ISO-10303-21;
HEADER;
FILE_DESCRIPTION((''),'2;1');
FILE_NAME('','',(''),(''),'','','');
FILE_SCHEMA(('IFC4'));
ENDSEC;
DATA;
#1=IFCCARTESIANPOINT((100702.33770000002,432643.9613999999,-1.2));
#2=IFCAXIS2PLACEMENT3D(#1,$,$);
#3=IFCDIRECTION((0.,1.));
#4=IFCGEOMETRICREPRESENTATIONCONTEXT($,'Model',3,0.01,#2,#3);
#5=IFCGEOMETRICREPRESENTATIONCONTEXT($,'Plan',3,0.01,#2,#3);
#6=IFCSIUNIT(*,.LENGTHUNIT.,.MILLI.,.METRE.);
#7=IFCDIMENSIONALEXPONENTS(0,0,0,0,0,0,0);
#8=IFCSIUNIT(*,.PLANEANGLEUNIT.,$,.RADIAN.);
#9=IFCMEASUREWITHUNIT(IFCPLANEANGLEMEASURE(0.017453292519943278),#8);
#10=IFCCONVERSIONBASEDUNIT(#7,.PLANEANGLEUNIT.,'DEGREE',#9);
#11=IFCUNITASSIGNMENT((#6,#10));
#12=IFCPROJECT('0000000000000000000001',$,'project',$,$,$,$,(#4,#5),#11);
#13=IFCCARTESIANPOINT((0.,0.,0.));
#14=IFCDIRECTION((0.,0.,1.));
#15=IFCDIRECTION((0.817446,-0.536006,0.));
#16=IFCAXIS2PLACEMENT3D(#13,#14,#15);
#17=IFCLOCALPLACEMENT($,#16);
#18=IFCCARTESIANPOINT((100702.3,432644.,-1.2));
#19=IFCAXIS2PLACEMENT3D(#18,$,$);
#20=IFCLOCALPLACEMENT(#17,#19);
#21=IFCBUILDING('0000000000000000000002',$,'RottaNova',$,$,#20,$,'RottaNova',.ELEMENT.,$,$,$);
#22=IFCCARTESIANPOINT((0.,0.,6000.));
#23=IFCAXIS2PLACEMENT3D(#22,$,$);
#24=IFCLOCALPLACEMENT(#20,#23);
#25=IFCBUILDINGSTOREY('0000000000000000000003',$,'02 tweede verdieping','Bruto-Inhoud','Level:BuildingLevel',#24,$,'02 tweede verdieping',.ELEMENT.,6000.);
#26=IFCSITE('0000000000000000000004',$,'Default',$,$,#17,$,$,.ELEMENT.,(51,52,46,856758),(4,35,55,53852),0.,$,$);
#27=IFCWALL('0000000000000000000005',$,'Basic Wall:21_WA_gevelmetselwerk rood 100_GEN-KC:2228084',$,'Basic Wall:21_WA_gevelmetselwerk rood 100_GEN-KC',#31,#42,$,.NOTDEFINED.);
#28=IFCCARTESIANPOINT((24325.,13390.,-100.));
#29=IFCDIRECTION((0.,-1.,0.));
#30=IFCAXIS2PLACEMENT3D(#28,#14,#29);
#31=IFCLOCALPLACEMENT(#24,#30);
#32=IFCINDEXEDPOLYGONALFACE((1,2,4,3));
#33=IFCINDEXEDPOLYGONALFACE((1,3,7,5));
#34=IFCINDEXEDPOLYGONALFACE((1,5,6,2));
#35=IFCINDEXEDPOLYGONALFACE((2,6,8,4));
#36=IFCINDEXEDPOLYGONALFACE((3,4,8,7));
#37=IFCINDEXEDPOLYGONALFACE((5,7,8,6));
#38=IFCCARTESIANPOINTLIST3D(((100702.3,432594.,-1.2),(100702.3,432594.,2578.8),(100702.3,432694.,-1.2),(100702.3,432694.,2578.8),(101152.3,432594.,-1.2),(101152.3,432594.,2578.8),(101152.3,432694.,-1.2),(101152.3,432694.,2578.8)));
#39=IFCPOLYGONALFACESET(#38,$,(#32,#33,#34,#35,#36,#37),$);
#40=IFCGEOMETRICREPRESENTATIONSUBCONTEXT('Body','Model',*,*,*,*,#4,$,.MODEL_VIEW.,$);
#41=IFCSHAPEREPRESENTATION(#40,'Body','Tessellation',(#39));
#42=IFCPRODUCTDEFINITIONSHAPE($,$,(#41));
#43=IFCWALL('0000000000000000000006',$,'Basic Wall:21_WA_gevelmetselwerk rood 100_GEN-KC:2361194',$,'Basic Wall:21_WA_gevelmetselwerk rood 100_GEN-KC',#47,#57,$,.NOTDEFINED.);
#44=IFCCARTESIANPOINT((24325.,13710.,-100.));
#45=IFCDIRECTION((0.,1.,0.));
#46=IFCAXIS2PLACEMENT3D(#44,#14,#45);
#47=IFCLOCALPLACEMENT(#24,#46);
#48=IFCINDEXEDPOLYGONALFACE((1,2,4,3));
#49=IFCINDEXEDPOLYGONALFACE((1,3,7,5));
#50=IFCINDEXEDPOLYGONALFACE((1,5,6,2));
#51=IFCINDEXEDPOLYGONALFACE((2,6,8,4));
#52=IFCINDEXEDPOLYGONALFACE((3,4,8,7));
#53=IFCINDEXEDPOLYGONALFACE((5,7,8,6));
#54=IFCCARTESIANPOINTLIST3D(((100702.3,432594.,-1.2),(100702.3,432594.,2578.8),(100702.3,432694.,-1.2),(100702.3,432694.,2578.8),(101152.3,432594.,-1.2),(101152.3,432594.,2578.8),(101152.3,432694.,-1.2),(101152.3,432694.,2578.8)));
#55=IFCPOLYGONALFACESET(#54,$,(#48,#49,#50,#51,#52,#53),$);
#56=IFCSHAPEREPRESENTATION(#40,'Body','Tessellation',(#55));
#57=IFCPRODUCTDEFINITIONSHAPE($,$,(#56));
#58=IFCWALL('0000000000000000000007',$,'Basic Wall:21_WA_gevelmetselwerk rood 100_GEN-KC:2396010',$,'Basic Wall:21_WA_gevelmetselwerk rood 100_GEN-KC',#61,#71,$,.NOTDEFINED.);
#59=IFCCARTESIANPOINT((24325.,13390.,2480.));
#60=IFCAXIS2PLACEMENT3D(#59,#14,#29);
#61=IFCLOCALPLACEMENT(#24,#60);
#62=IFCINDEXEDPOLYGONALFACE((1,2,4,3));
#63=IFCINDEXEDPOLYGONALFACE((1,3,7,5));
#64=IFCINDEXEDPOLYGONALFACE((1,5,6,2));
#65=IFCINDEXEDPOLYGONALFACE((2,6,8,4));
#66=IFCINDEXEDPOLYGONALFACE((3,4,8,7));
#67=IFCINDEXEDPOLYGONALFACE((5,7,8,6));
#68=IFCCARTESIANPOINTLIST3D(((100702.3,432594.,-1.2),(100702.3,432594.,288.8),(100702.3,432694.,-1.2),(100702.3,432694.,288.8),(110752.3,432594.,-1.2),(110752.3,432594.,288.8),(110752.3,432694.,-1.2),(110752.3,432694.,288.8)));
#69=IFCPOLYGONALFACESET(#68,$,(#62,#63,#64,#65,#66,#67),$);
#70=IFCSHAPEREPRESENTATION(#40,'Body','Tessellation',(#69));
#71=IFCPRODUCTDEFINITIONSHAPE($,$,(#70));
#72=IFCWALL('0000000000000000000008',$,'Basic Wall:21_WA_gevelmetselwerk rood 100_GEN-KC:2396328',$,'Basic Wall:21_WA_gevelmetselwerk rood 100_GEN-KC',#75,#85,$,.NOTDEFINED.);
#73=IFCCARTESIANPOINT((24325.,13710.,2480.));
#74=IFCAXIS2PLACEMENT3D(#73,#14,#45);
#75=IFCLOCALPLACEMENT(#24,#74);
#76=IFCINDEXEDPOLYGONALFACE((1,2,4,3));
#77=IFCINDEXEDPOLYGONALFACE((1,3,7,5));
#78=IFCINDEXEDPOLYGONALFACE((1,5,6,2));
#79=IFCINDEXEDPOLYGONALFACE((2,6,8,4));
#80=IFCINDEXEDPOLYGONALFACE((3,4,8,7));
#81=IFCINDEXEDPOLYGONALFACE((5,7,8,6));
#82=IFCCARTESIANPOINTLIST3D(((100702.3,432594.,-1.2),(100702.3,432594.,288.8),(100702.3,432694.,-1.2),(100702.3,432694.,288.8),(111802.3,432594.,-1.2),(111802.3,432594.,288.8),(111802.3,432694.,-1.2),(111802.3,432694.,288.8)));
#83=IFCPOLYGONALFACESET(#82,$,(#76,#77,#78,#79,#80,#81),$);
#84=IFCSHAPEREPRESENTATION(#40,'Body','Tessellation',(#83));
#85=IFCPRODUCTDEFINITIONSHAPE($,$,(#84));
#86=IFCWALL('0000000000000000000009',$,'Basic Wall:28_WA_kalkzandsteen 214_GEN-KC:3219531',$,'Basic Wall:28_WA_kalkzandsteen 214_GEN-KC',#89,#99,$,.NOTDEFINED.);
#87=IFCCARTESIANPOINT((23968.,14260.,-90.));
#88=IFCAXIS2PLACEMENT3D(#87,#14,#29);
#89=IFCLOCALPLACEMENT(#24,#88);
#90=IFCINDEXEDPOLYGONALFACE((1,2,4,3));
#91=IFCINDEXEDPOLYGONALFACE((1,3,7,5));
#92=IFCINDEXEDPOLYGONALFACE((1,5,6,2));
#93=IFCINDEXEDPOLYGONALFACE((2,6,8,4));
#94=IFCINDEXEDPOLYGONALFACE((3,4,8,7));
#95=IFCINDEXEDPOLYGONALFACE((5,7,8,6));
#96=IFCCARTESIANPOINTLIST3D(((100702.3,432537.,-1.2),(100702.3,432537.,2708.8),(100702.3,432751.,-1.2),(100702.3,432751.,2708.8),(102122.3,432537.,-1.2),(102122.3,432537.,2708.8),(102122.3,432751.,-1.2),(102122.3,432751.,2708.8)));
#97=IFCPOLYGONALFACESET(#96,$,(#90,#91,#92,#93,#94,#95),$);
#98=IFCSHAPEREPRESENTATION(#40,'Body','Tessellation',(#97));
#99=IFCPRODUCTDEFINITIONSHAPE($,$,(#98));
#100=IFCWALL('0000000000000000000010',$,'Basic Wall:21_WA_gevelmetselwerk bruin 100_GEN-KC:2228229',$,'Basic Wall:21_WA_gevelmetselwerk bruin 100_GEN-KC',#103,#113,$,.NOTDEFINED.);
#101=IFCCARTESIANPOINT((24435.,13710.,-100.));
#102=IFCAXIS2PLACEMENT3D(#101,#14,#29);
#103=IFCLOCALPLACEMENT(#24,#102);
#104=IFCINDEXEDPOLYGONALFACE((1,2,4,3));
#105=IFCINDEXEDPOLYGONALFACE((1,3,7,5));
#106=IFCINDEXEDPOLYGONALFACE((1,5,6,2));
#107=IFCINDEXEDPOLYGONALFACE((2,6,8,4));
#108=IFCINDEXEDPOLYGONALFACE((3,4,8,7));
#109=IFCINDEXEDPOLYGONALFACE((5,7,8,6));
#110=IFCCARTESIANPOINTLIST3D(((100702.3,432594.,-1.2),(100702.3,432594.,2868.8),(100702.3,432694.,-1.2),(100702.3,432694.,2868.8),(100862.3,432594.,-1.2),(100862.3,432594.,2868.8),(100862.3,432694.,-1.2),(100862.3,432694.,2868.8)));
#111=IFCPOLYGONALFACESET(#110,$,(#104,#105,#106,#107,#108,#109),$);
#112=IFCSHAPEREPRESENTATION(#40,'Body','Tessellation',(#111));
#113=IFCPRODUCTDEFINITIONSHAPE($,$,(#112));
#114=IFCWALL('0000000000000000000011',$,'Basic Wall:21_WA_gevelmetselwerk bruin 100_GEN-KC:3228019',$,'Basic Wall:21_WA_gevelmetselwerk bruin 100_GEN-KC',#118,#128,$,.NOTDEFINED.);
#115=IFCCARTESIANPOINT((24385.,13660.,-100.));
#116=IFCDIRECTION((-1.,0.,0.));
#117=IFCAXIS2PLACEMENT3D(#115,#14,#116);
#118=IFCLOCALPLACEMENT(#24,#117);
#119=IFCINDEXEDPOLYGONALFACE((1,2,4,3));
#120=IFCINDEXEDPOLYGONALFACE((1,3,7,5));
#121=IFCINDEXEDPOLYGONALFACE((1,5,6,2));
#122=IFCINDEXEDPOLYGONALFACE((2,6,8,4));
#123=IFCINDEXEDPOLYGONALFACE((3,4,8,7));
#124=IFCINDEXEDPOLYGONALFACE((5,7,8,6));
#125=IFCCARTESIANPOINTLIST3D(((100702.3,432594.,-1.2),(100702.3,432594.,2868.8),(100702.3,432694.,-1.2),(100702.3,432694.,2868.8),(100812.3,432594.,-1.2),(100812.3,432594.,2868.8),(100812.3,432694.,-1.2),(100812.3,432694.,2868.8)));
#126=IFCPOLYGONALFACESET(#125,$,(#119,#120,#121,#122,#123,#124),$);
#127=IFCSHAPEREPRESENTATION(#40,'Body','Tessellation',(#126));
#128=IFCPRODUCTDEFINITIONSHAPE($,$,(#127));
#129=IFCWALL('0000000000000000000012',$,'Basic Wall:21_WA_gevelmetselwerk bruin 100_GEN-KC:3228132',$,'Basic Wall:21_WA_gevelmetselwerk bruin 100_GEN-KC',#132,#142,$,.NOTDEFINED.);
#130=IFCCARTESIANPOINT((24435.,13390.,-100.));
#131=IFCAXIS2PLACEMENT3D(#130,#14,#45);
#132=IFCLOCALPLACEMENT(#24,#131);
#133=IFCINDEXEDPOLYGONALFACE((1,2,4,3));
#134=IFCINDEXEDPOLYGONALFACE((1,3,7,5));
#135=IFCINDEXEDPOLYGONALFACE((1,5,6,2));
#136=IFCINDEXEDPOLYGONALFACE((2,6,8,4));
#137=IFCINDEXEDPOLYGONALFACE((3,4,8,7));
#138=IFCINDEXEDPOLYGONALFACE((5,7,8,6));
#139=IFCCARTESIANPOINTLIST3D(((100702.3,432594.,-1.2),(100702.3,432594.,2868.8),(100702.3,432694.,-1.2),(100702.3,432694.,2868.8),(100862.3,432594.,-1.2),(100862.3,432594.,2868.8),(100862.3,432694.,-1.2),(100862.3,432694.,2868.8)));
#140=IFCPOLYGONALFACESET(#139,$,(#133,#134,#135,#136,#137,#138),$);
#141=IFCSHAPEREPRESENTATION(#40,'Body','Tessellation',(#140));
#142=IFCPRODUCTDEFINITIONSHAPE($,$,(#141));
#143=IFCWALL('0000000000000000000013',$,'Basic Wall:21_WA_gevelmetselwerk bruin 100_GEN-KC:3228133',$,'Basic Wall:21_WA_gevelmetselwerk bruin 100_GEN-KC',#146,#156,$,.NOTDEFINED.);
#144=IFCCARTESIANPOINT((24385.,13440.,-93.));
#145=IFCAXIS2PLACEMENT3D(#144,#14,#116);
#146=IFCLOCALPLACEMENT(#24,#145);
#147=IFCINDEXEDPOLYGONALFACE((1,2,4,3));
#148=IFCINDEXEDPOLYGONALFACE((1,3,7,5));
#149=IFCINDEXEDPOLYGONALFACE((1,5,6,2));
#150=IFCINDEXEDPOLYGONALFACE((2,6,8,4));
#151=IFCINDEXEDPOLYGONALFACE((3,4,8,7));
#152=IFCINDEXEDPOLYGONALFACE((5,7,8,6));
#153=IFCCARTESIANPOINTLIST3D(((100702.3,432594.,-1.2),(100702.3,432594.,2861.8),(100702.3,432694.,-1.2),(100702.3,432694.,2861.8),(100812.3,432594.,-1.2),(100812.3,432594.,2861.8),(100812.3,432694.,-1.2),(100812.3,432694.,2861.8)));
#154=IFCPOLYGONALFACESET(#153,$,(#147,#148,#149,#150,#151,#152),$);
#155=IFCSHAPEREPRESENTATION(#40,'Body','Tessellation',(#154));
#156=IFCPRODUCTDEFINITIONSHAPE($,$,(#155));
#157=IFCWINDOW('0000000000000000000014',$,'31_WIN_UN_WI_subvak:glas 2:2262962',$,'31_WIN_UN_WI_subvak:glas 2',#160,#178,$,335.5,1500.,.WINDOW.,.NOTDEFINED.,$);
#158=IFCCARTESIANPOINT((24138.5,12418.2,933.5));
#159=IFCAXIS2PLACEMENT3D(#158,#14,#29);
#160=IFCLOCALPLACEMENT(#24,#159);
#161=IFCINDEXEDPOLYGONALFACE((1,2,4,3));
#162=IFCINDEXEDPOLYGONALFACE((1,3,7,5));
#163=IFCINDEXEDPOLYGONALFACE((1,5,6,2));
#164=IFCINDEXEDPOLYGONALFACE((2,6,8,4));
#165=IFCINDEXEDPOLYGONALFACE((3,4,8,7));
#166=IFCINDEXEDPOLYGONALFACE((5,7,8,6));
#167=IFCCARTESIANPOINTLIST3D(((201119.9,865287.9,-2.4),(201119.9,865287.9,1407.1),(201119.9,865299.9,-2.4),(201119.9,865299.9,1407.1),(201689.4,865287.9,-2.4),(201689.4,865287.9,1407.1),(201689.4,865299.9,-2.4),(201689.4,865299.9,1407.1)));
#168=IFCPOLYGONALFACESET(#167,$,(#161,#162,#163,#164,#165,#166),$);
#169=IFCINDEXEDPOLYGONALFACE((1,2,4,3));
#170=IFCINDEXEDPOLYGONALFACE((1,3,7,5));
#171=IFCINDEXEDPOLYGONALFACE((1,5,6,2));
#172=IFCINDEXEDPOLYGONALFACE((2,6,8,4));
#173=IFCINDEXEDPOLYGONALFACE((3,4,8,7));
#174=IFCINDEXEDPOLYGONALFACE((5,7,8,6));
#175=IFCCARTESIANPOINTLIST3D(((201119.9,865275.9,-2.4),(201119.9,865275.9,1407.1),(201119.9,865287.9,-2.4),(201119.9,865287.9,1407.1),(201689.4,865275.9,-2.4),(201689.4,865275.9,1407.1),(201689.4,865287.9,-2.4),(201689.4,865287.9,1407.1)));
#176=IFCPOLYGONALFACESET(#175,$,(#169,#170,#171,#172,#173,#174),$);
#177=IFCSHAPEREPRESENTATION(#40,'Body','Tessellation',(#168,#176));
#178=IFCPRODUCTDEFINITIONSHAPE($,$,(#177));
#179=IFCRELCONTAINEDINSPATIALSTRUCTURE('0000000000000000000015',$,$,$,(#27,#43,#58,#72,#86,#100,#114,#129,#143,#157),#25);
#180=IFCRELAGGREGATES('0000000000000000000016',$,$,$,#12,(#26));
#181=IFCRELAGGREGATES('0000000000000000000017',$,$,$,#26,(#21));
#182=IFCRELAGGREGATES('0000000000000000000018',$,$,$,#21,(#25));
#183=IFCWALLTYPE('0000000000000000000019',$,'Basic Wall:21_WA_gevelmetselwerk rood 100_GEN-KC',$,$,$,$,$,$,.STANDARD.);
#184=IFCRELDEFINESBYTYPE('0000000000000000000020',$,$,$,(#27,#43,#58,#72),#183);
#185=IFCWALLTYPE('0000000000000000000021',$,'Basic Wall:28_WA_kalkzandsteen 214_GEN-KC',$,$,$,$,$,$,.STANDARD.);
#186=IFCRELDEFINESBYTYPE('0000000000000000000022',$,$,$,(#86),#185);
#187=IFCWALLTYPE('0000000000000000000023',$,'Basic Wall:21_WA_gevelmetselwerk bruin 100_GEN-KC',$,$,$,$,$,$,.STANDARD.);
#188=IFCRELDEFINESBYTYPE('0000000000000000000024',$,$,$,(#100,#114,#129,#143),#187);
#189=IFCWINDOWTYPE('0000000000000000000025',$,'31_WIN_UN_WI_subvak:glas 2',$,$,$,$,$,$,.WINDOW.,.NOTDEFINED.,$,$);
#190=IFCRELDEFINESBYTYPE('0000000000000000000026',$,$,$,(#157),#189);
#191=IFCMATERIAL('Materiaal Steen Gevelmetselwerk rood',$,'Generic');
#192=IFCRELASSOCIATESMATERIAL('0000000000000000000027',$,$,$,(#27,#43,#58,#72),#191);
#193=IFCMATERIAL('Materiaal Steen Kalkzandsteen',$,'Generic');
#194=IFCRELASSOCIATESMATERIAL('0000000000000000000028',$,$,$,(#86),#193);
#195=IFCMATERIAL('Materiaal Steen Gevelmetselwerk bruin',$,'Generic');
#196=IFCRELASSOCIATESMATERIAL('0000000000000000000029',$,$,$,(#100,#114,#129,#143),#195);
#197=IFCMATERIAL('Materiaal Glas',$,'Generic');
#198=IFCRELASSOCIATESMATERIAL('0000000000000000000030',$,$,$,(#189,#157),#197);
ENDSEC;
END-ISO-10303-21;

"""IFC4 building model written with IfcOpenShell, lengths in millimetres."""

from ifc_helpers import new_model, entity, si_unit, converted_unit, direction, frame, place, context, subcontext, project, spatial, indexed_curve, outline, extrude, source, transform, mapped, material, type_object, type_shapes, element, save


model = new_model("IFC4")

# Units and contexts
model_context = context("Model", 3, precision=0.01, world=frame((100702.33770000002, 432643.9613999999, -1.2)), true_north=direction((0.0, 1.0)))
plan_context = context("Plan", 3, precision=0.01, world=frame((100702.33770000002, 432643.9613999999, -1.2)), true_north=direction((0.0, 1.0)))
body_context = subcontext(model_context, "Body", "Model", "MODEL_VIEW")
ifc_project = project(units=[si_unit("LENGTHUNIT", "METRE", prefix="MILLI"), converted_unit("PLANEANGLEUNIT", "DEGREE", entity("IfcPlaneAngleMeasure", 0.017453292519943278), si_unit("PLANEANGLEUNIT", "RADIAN"), dimensions=[0, 0, 0, 0, 0, 0, 0])], contexts=[model_context, plan_context])

# Site, building, storey
site_placement = place(None, frame((0.0, 0.0, 0.0), z_axis=(0.0, 0.0, 1.0), x_axis=(0.817446, -0.536006, 0.0)))
site = spatial("IfcSite", under=ifc_project, at=site_placement, Name="Default", CompositionType="ELEMENT", RefLatitude=(51, 52, 46, 856758), RefLongitude=(4, 35, 55, 53852), RefElevation=0.0)
building_placement = place(site_placement, frame((100702.3, 432644.0, -1.2)))
building = spatial("IfcBuilding", under=site, at=building_placement, Name="RottaNova", LongName="RottaNova", CompositionType="ELEMENT")
storey_placement = place(building_placement, frame((0.0, 0.0, 6000.0)))
storey = spatial("IfcBuildingStorey", under=building, at=storey_placement, Name="02 tweede verdieping", Description="Bruto-Inhoud", ObjectType="Level:BuildingLevel", LongName="02 tweede verdieping", CompositionType="ELEMENT", Elevation=6000.0)

# Shared definitions
ifc_material_1 = material(Name="Materiaal Glas", Category="Generic")

# Walls
ifc_material_2 = material(Name="Materiaal Steen Gevelmetselwerk rood", Category="Generic")
wall_type_1 = type_object("IfcWallType", Name="Basic Wall:21_WA_gevelmetselwerk rood 100_GEN-KC", PredefinedType="STANDARD")
wall_1_placement = place(storey_placement, frame((24325.0, 13390.0, -100.0), z_axis=(0.0, 0.0, 1.0), x_axis=(0.0, -1.0, 0.0)))
element("IfcWall", 1, at=wall_1_placement, inside=storey, type_object=wall_type_1, material=ifc_material_2, Name="Basic Wall:21_WA_gevelmetselwerk rood 100_GEN-KC:2228084", ObjectType="Basic Wall:21_WA_gevelmetselwerk rood 100_GEN-KC", PredefinedType="NOTDEFINED", context=body_context, shape_type="SweptSolid", body=[
    extrude(outline(indexed_curve([(450.0, 50.0), (0.0, 50.0), (0.0, -50.0), (450.0, -50.0), (450.0, 50.0)], self_intersect=False)), frame((100702.3, 432644.0, -1.2)), (0.0, 0.0, 1.0), 2580.0),
])
wall_2_placement = place(storey_placement, frame((24325.0, 13710.0, -100.0), z_axis=(0.0, 0.0, 1.0), x_axis=(0.0, 1.0, 0.0)))
element("IfcWall", 2, at=wall_2_placement, inside=storey, type_object=wall_type_1, material=ifc_material_2, Name="Basic Wall:21_WA_gevelmetselwerk rood 100_GEN-KC:2361194", ObjectType="Basic Wall:21_WA_gevelmetselwerk rood 100_GEN-KC", PredefinedType="NOTDEFINED", context=body_context, shape_type="SweptSolid", body=[
    extrude(outline(indexed_curve([(450.0, 50.0), (0.0, 50.0), (0.0, -50.0), (450.0, -50.0), (450.0, 50.0)], self_intersect=False)), frame((100702.3, 432644.0, -1.2)), (0.0, 0.0, 1.0), 2580.0),
])
wall_3_placement = place(storey_placement, frame((24325.0, 13390.0, 2480.0), z_axis=(0.0, 0.0, 1.0), x_axis=(0.0, -1.0, 0.0)))
element("IfcWall", 3, at=wall_3_placement, inside=storey, type_object=wall_type_1, material=ifc_material_2, Name="Basic Wall:21_WA_gevelmetselwerk rood 100_GEN-KC:2396010", ObjectType="Basic Wall:21_WA_gevelmetselwerk rood 100_GEN-KC", PredefinedType="NOTDEFINED", context=body_context, shape_type="SweptSolid", body=[
    extrude(outline(indexed_curve([(10050.0, 50.0), (0.0, 50.0), (0.0, -50.0), (10050.0, -50.0), (10050.0, 50.0)], self_intersect=False)), frame((100702.3, 432644.0, -1.2)), (0.0, 0.0, 1.0), 290.0),
])
wall_4_placement = place(storey_placement, frame((24325.0, 13710.0, 2480.0), z_axis=(0.0, 0.0, 1.0), x_axis=(0.0, 1.0, 0.0)))
element("IfcWall", 4, at=wall_4_placement, inside=storey, type_object=wall_type_1, material=ifc_material_2, Name="Basic Wall:21_WA_gevelmetselwerk rood 100_GEN-KC:2396328", ObjectType="Basic Wall:21_WA_gevelmetselwerk rood 100_GEN-KC", PredefinedType="NOTDEFINED", context=body_context, shape_type="SweptSolid", body=[
    extrude(outline(indexed_curve([(11100.0, 50.0), (0.0, 50.0), (0.0, -50.0), (11100.0, -50.0), (11100.0, 50.0)], self_intersect=False)), frame((100702.3, 432644.0, -1.2)), (0.0, 0.0, 1.0), 290.0),
])
ifc_material_3 = material(Name="Materiaal Steen Kalkzandsteen", Category="Generic")
wall_type_2 = type_object("IfcWallType", Name="Basic Wall:28_WA_kalkzandsteen 214_GEN-KC", PredefinedType="STANDARD")
wall_5_placement = place(storey_placement, frame((23968.0, 14260.0, -90.0), z_axis=(0.0, 0.0, 1.0), x_axis=(0.0, -1.0, 0.0)))
element("IfcWall", 5, at=wall_5_placement, inside=storey, type_object=wall_type_2, material=ifc_material_3, Name="Basic Wall:28_WA_kalkzandsteen 214_GEN-KC:3219531", ObjectType="Basic Wall:28_WA_kalkzandsteen 214_GEN-KC", PredefinedType="NOTDEFINED", context=body_context, shape_type="SweptSolid", body=[
    extrude(outline(indexed_curve([(1420.0, 107.0), (0.0, 107.0), (0.0, -107.0), (1420.0, -107.0), (1420.0, 107.0)], self_intersect=False)), frame((100702.3, 432644.0, -1.2)), (0.0, 0.0, 1.0), 2710.0),
])
ifc_material_4 = material(Name="Materiaal Steen Gevelmetselwerk bruin", Category="Generic")
wall_type_3 = type_object("IfcWallType", Name="Basic Wall:21_WA_gevelmetselwerk bruin 100_GEN-KC", PredefinedType="STANDARD")
wall_6_placement = place(storey_placement, frame((24435.0, 13710.0, -100.0), z_axis=(0.0, 0.0, 1.0), x_axis=(0.0, -1.0, 0.0)))
element("IfcWall", 6, at=wall_6_placement, inside=storey, type_object=wall_type_3, material=ifc_material_4, Name="Basic Wall:21_WA_gevelmetselwerk bruin 100_GEN-KC:2228229", ObjectType="Basic Wall:21_WA_gevelmetselwerk bruin 100_GEN-KC", PredefinedType="NOTDEFINED", context=body_context, shape_type="SweptSolid", body=[
    extrude(outline(indexed_curve([(160.0, 50.0), (0.0, 50.0), (0.0, -50.0), (160.0, -50.0), (160.0, 50.0)], self_intersect=False)), frame((100702.3, 432644.0, -1.2)), (0.0, 0.0, 1.0), 2870.0),
])
wall_7_placement = place(storey_placement, frame((24385.0, 13660.0, -100.0), z_axis=(0.0, 0.0, 1.0), x_axis=(-1.0, 0.0, 0.0)))
element("IfcWall", 7, at=wall_7_placement, inside=storey, type_object=wall_type_3, material=ifc_material_4, Name="Basic Wall:21_WA_gevelmetselwerk bruin 100_GEN-KC:3228019", ObjectType="Basic Wall:21_WA_gevelmetselwerk bruin 100_GEN-KC", PredefinedType="NOTDEFINED", context=body_context, shape_type="SweptSolid", body=[
    extrude(outline(indexed_curve([(110.0, 50.0), (0.0, 50.0), (0.0, -50.0), (110.0, -50.0), (110.0, 50.0)], self_intersect=False)), frame((100702.3, 432644.0, -1.2)), (0.0, 0.0, 1.0), 2870.0),
])
wall_8_placement = place(storey_placement, frame((24435.0, 13390.0, -100.0), z_axis=(0.0, 0.0, 1.0), x_axis=(0.0, 1.0, 0.0)))
element("IfcWall", 8, at=wall_8_placement, inside=storey, type_object=wall_type_3, material=ifc_material_4, Name="Basic Wall:21_WA_gevelmetselwerk bruin 100_GEN-KC:3228132", ObjectType="Basic Wall:21_WA_gevelmetselwerk bruin 100_GEN-KC", PredefinedType="NOTDEFINED", context=body_context, shape_type="SweptSolid", body=[
    extrude(outline(indexed_curve([(160.0, 50.0), (0.0, 50.0), (0.0, -50.0), (160.0, -50.0), (160.0, 50.0)], self_intersect=False)), frame((100702.3, 432644.0, -1.2)), (0.0, 0.0, 1.0), 2870.0),
])
wall_9_placement = place(storey_placement, frame((24385.0, 13440.0, -93.0), z_axis=(0.0, 0.0, 1.0), x_axis=(-1.0, 0.0, 0.0)))
element("IfcWall", 9, at=wall_9_placement, inside=storey, type_object=wall_type_3, material=ifc_material_4, Name="Basic Wall:21_WA_gevelmetselwerk bruin 100_GEN-KC:3228133", ObjectType="Basic Wall:21_WA_gevelmetselwerk bruin 100_GEN-KC", PredefinedType="NOTDEFINED", context=body_context, shape_type="SweptSolid", body=[
    extrude(outline(indexed_curve([(110.0, 50.0), (0.0, 50.0), (0.0, -50.0), (110.0, -50.0), (110.0, 50.0)], self_intersect=False)), frame((100702.3, 432644.0, -1.2)), (0.0, 0.0, 1.0), 2863.0),
])

# Window
window_type_1 = type_object("IfcWindowType", Name="31_WIN_UN_WI_subvak:glas 2", PartitioningType="NOTDEFINED", PredefinedType="WINDOW", material=ifc_material_1)
shared_shape_1 = source(frame((100702.3, 432644.0, -1.2)), body_context, "Body", "SweptSolid", [
    extrude(outline(indexed_curve([(-6.0, -284.7), (6.0, -284.7), (6.0, 284.7), (-6.0, 284.7), (-6.0, -284.7)], self_intersect=False)), frame((0.0, 6.0, 0.0), z_axis=(0.0, 0.0, 1.0), x_axis=(0.0, -1.0, 0.0)), (0.0, 0.0, 1.0), 1409.5),
    extrude(outline(indexed_curve([(-6.0, -284.8), (6.0, -284.8), (6.0, 284.8), (-6.0, 284.8), (-6.0, -284.8)], self_intersect=False)), frame((0.0, -6.0, 0.0), z_axis=(0.0, 0.0, 1.0), x_axis=(0.0, -1.0, 0.0)), (0.0, 0.0, 1.0), 1409.5),
])
type_shapes(window_type_1, [shared_shape_1])
for number, where, z_axis, x_axis, name in (
    (10, (24138.5, 12418.2, 933.5), (0.0, 0.0, 1.0), (0.0, -1.0, 0.0), "31_WIN_UN_WI_subvak:glas 2:2262962"),
):
    element("IfcWindow", number, at=place(storey_placement, frame(where, z_axis=z_axis, x_axis=x_axis)), inside=storey, type_object=window_type_1, material=ifc_material_1, Name=name, ObjectType="31_WIN_UN_WI_subvak:glas 2", OverallHeight=335.5, OverallWidth=1500.0, PartitioningType="NOTDEFINED", PredefinedType="WINDOW", context=body_context, shape_type="MappedRepresentation", body=[
        mapped(shared_shape_1, transform((100702.3, 432644.0, -1.2), scale=1.0)),
    ])

save(model, "model.ifc")
